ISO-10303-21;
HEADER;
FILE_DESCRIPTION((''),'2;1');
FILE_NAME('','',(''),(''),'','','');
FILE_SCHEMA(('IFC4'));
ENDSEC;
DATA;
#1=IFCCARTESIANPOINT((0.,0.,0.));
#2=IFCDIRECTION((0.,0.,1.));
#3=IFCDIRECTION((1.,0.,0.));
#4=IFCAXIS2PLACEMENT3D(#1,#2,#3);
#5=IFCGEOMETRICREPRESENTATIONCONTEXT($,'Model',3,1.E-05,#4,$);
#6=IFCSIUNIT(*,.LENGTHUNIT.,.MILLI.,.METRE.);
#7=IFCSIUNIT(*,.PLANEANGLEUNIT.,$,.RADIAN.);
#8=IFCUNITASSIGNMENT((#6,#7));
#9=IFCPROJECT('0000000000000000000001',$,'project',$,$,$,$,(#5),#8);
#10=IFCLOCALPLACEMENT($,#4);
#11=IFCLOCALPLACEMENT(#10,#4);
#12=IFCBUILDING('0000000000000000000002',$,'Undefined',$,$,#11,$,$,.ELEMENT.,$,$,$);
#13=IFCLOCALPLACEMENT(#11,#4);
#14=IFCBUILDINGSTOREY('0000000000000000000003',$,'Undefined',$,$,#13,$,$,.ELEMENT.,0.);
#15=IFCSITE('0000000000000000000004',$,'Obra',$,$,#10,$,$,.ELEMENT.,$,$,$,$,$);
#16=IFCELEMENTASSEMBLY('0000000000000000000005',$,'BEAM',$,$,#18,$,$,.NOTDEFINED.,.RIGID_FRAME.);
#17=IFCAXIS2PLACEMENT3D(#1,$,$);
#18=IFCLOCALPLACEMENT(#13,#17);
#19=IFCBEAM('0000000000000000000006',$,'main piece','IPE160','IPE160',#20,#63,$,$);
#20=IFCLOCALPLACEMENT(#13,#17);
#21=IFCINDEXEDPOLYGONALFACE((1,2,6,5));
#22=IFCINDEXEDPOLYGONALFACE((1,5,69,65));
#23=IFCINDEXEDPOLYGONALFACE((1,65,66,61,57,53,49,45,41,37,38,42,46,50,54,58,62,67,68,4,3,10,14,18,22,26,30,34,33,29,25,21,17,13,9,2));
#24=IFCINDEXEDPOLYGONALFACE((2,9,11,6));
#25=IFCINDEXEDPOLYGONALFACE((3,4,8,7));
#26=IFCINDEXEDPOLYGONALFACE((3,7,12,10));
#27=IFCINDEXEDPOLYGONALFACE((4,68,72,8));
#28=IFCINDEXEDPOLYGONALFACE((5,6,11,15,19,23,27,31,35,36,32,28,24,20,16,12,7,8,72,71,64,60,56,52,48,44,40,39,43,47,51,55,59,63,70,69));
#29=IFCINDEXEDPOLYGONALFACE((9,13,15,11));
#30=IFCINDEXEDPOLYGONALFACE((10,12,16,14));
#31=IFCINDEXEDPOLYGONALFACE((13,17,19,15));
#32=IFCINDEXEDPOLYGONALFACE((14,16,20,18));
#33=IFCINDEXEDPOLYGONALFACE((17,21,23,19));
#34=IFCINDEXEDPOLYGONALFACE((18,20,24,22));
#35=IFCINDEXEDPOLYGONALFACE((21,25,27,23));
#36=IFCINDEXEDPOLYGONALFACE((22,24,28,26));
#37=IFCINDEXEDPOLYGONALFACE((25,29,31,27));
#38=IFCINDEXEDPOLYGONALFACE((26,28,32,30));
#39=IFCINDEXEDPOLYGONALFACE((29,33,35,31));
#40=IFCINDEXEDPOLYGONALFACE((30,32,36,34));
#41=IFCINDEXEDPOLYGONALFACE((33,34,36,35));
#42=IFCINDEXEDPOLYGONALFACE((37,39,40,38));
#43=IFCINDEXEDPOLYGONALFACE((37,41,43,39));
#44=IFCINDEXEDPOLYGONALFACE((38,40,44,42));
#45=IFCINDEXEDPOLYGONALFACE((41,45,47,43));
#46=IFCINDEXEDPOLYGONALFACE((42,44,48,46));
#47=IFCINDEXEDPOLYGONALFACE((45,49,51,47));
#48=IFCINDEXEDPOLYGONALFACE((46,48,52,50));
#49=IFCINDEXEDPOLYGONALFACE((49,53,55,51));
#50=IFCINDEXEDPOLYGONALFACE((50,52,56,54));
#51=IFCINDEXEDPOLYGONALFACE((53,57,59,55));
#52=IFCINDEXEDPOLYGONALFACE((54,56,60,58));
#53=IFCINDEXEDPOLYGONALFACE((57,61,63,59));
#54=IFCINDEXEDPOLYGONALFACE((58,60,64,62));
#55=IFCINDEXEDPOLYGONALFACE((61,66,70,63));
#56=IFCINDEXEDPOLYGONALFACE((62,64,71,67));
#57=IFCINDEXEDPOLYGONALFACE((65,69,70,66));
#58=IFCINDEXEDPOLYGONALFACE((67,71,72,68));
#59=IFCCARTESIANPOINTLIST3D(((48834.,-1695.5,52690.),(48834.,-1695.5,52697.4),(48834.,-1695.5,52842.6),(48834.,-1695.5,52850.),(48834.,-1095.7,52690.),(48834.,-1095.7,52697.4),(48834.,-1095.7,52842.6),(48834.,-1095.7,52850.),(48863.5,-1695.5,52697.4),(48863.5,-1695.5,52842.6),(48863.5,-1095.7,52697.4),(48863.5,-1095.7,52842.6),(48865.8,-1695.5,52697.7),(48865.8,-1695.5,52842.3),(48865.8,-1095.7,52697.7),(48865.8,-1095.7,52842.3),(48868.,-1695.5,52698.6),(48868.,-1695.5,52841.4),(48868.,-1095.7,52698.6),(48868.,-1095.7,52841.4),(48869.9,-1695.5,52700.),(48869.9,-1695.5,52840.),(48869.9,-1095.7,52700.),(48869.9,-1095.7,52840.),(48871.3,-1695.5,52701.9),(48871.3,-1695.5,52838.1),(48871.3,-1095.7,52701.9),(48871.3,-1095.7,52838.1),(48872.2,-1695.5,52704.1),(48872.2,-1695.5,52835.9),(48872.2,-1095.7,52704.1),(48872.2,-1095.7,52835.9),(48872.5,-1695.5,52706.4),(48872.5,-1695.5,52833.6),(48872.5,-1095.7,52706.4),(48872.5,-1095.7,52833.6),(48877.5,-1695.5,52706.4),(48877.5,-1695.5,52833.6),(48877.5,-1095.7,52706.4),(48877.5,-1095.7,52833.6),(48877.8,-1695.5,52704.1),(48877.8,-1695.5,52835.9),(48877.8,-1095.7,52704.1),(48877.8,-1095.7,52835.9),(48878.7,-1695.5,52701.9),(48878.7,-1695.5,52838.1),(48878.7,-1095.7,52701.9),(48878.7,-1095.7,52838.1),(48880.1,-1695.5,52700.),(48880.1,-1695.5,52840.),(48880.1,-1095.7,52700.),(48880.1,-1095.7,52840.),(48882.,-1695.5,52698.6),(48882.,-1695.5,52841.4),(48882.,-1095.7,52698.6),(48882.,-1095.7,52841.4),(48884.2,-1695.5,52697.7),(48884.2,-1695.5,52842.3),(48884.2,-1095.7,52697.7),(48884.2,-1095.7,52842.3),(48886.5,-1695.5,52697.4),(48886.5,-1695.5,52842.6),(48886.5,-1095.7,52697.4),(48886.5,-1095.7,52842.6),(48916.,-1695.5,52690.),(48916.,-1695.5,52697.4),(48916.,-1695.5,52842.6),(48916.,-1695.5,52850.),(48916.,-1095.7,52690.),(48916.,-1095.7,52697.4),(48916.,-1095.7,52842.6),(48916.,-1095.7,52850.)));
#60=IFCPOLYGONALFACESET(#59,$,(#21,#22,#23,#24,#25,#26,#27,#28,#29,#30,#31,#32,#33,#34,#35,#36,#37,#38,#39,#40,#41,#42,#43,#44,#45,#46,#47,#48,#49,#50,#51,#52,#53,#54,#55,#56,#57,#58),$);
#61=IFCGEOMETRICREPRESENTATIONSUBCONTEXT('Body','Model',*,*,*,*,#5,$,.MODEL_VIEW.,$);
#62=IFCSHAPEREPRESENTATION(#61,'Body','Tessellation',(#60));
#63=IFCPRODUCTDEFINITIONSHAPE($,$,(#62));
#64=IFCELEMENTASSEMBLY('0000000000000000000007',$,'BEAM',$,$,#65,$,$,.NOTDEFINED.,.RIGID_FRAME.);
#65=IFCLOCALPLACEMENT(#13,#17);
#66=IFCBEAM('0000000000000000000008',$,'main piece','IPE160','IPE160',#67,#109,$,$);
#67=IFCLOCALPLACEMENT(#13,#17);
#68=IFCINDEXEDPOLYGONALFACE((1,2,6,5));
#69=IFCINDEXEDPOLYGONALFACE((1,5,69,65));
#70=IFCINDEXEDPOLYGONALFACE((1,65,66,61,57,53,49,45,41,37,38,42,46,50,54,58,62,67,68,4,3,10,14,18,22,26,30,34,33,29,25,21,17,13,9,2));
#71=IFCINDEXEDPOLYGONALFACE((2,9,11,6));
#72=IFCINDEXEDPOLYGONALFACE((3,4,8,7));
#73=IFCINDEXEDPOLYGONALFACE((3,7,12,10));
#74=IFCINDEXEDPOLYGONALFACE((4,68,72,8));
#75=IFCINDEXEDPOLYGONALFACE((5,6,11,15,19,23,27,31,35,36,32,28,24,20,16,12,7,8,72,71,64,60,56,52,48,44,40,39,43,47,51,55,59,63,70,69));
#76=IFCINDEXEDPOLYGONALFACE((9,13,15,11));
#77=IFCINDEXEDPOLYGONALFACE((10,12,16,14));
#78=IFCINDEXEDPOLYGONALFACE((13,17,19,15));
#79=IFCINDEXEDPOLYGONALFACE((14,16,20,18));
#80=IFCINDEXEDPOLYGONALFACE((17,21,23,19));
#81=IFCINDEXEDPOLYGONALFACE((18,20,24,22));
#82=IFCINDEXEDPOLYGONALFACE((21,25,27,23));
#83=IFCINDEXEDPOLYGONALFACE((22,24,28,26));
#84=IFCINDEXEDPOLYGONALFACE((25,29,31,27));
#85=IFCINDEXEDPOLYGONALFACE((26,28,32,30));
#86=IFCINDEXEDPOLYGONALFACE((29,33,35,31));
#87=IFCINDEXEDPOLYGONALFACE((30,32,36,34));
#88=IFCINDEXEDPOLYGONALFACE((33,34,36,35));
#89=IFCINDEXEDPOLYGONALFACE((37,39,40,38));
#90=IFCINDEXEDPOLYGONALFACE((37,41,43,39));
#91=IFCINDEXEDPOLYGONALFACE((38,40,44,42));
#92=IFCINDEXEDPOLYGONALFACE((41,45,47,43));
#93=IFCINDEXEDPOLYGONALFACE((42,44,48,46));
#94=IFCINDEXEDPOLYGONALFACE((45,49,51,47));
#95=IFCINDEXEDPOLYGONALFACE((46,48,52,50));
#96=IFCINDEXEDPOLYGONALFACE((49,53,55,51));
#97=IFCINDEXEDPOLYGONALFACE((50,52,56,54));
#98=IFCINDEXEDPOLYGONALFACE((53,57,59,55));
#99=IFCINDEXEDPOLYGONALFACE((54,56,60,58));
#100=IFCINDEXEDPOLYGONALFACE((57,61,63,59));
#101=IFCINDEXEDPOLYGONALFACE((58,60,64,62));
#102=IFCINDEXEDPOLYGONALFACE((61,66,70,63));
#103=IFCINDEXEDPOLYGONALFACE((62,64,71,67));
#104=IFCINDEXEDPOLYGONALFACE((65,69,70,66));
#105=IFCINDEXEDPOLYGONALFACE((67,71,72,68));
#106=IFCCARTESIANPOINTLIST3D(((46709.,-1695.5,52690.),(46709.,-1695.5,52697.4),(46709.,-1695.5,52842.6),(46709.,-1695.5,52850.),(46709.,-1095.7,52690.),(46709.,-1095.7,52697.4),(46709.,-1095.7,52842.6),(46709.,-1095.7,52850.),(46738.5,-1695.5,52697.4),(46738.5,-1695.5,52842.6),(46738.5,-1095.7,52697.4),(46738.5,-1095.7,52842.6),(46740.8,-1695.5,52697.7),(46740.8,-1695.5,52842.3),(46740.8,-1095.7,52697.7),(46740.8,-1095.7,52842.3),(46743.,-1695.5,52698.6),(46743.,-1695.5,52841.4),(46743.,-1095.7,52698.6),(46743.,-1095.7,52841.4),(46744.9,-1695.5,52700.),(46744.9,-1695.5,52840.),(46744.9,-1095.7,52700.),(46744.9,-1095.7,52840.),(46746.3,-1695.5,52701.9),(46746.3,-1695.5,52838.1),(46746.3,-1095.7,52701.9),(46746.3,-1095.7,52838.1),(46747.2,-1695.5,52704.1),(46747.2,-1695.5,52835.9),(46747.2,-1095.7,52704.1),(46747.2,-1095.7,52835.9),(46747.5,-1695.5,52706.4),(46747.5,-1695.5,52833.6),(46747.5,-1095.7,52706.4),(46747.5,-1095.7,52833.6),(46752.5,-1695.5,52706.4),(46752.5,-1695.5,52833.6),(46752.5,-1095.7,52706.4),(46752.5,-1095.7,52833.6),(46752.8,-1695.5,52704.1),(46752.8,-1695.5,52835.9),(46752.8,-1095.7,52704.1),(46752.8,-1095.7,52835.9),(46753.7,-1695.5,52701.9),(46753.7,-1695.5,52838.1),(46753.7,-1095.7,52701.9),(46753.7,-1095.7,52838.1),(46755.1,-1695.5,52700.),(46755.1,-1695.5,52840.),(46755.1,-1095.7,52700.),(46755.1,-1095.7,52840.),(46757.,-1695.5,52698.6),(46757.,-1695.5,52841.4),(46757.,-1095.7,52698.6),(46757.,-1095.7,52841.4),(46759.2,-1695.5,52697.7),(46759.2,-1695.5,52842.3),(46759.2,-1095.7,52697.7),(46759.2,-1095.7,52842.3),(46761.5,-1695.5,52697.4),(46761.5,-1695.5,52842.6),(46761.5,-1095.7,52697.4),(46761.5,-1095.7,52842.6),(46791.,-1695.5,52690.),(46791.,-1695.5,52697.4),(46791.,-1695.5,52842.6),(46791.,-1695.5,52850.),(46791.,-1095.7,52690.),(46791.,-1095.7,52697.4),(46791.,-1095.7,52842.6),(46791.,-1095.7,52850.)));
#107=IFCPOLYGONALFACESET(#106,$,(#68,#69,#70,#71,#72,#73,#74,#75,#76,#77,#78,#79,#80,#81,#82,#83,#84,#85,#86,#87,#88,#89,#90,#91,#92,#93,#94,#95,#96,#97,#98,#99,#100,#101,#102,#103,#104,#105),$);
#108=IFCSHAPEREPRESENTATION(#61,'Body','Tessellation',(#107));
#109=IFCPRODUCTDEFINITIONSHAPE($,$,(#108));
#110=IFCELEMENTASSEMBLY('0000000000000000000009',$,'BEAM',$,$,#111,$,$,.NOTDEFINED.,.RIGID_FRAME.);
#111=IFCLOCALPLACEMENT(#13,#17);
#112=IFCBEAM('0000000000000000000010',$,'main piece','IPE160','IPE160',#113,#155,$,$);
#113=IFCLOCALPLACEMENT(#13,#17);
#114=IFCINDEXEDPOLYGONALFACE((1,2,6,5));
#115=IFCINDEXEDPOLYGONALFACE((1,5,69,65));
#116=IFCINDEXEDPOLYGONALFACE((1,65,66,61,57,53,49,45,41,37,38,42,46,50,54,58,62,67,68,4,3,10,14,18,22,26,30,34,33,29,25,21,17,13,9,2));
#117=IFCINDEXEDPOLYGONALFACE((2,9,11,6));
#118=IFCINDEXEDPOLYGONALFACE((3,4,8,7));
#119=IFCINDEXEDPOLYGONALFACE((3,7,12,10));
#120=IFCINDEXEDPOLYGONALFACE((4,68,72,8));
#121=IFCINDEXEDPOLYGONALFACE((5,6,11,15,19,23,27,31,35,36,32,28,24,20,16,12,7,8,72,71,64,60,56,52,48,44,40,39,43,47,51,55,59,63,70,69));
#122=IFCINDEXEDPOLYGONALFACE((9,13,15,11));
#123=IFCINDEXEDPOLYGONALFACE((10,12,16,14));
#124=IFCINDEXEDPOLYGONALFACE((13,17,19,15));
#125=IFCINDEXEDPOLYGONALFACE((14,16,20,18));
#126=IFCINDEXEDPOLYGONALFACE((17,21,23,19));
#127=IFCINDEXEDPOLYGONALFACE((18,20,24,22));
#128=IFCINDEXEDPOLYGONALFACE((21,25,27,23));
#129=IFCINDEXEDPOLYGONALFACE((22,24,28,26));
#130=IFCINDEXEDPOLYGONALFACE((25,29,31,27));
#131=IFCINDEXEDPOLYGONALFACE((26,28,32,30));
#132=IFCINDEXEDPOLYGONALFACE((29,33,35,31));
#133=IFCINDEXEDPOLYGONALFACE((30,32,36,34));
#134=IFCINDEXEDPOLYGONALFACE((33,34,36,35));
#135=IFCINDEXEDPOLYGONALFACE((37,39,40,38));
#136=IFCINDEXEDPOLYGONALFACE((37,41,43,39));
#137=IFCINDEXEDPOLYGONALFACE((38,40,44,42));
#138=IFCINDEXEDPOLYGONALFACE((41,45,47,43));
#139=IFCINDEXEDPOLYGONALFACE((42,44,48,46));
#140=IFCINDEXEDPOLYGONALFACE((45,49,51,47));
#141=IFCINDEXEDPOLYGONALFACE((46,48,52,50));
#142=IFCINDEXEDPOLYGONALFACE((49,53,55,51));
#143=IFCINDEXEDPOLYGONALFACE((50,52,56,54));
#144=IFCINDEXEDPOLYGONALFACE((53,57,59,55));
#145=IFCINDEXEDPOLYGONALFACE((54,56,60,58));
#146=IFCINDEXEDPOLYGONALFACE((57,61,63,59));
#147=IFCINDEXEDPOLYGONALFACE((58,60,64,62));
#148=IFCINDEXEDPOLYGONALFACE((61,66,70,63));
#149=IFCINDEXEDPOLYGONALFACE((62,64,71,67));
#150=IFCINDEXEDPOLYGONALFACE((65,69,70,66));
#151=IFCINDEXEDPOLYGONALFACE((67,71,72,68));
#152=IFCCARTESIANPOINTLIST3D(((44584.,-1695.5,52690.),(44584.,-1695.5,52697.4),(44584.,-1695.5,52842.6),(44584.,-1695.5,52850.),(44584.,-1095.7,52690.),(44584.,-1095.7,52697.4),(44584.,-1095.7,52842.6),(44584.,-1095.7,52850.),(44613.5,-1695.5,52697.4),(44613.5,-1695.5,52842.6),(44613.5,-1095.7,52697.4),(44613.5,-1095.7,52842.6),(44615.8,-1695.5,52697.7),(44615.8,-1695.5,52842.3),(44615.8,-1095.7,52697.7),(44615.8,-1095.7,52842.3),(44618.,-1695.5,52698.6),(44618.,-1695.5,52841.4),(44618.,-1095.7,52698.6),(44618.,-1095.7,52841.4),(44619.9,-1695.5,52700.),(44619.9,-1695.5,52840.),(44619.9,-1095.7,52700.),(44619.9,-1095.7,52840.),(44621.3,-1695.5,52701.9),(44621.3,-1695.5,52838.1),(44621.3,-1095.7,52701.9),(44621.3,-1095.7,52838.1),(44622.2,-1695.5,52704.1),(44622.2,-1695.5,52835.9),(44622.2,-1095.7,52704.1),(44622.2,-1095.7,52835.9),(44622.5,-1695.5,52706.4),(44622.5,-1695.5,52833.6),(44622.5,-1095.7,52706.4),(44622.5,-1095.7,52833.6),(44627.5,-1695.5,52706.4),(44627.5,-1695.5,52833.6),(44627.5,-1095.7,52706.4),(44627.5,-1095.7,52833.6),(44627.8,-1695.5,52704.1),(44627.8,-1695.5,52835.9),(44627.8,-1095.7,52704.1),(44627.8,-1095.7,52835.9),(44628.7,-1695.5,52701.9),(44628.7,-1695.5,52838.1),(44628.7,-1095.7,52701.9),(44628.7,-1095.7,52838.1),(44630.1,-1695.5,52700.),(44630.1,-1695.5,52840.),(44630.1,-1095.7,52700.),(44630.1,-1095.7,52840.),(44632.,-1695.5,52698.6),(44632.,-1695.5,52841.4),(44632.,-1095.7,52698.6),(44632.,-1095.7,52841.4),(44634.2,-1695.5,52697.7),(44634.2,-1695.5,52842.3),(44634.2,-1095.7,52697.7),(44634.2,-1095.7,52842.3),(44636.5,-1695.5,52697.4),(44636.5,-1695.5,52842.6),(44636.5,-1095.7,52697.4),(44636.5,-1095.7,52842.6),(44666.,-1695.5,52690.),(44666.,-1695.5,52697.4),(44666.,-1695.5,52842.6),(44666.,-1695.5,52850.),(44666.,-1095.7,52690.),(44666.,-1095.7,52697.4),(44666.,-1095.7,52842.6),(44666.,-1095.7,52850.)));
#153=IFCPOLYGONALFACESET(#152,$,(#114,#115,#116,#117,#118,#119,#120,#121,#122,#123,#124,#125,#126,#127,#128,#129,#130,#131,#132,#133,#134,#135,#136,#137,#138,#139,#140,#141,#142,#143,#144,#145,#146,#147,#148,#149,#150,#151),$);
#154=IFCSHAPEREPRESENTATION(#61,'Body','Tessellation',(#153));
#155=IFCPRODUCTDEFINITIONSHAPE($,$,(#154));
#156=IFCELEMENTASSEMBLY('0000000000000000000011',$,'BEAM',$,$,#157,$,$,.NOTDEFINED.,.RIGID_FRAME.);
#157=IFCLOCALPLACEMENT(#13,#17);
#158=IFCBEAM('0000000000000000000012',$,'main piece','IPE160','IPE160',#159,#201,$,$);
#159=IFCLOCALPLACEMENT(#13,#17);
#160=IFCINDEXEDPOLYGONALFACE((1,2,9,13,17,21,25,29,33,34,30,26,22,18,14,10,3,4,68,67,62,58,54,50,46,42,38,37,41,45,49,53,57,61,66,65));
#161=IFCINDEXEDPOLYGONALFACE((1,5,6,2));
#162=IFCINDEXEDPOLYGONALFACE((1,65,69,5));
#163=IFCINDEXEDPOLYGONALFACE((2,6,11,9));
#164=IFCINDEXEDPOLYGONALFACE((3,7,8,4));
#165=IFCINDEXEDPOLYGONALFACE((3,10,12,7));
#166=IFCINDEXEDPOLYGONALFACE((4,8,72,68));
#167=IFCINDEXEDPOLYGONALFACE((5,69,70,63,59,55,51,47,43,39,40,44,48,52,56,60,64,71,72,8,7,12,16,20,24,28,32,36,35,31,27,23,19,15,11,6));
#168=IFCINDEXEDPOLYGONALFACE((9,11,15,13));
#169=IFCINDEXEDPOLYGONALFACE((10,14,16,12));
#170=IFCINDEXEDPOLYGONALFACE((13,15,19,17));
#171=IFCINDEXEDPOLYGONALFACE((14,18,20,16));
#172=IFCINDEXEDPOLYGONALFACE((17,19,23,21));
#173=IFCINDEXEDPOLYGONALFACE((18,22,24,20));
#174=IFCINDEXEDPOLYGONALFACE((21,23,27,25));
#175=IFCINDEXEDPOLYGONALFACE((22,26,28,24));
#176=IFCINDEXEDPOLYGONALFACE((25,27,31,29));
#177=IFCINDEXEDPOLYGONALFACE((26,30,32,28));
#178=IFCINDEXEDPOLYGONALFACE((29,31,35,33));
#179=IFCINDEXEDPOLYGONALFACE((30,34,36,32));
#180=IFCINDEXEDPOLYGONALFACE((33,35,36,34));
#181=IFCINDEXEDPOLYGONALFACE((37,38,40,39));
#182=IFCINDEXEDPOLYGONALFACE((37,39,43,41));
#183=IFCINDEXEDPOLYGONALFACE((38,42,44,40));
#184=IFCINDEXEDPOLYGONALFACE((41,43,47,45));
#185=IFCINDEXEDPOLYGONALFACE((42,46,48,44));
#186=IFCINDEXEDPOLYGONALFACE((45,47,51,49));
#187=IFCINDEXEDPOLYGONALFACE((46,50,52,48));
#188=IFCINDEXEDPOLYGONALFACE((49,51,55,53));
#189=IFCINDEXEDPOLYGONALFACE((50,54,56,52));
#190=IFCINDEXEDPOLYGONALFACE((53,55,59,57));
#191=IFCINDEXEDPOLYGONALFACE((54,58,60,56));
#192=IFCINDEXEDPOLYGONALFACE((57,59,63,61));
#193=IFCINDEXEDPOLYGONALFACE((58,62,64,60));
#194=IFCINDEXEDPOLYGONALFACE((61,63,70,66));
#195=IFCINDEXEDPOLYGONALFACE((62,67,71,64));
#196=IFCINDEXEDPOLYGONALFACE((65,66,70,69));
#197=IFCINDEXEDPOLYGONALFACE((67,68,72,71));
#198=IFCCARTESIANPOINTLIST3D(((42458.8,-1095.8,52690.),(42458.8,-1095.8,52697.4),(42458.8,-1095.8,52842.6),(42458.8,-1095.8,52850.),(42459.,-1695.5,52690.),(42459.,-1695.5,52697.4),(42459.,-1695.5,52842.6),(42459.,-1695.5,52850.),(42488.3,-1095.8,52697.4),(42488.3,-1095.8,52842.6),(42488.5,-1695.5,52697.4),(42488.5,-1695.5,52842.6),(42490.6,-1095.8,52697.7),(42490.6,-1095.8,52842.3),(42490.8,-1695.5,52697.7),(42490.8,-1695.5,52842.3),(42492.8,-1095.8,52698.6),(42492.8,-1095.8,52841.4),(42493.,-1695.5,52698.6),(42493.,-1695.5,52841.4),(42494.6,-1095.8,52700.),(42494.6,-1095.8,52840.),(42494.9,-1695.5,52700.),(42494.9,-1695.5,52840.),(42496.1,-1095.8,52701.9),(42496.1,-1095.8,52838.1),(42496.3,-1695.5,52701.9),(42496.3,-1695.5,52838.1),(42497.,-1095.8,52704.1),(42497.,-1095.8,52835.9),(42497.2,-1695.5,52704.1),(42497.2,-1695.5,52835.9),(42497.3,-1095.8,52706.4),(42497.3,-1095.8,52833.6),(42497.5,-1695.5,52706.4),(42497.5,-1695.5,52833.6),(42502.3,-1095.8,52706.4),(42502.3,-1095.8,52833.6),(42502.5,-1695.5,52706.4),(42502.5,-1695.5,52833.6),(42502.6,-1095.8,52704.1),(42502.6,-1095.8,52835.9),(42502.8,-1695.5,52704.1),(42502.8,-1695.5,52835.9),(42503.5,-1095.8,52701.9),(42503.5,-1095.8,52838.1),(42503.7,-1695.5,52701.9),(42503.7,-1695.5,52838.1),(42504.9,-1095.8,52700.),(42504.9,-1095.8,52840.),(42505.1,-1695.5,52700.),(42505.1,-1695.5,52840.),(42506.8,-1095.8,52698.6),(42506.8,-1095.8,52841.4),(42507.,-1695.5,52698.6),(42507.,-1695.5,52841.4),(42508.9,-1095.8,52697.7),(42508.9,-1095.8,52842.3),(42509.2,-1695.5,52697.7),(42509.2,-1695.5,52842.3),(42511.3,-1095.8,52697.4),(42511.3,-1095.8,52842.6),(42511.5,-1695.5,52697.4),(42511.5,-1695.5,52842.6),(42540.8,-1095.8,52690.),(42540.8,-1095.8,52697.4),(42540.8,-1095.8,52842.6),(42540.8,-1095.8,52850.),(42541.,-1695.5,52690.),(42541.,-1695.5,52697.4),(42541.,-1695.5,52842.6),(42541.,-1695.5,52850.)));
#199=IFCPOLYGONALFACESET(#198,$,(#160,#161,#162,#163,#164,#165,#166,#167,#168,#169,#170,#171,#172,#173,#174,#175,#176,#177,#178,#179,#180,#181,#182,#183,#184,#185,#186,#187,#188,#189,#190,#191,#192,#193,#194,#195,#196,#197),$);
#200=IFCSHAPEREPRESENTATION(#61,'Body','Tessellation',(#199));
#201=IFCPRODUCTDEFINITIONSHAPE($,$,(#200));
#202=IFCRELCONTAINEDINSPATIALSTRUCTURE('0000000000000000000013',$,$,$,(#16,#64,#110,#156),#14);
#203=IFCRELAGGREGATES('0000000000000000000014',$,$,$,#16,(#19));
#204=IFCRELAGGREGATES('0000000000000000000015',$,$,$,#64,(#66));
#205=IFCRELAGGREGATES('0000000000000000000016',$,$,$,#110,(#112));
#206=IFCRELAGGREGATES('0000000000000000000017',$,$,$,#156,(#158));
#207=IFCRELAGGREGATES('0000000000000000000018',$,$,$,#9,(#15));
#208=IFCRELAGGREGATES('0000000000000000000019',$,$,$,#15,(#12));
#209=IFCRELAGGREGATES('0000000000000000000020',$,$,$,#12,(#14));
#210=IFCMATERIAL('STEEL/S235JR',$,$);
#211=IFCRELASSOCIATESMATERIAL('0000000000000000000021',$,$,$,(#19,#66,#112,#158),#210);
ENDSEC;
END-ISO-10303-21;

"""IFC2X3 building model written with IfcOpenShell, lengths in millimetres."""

from ifc_helpers import new_model, si_unit, frame, origin_with_axes, origin_2d_with_axis, place, context, subcontext, project, spatial, i_section, extrude, material, element, aggregate, save


model = new_model("IFC2X3")

# Units and contexts
model_context = context("Model", 3, precision=1e-05, world=origin_with_axes())
body_context = subcontext(model_context, "Body", "Model", "MODEL_VIEW")
ifc_project = project(units=[si_unit("LENGTHUNIT", "METRE", prefix="MILLI"), si_unit("PLANEANGLEUNIT", "RADIAN")], contexts=[model_context])

# Site, building, storey
site_placement = place(None, origin_with_axes())
site = spatial("IfcSite", under=ifc_project, at=site_placement, Name="Obra", CompositionType="ELEMENT")
building_placement = place(site_placement, origin_with_axes())
building = spatial("IfcBuilding", under=site, at=building_placement, Name="Undefined", CompositionType="ELEMENT")
storey_placement = place(building_placement, origin_with_axes())
storey = spatial("IfcBuildingStorey", under=building, at=storey_placement, Name="Undefined", CompositionType="ELEMENT", Elevation=0.0)

# Shared definitions
ifc_material_1 = material(Name="STEEL/S235JR")

# Element assemblies, beams
assembly_1_placement = place(storey_placement, origin_with_axes())
assembly_1 = element("IfcElementAssembly", 1, at=assembly_1_placement, inside=storey, Name="BEAM", AssemblyPlace="NOTDEFINED", PredefinedType="RIGID_FRAME")
beam_1_placement = place(assembly_1_placement, frame((48875.0, -1695.5, 52770.0), z_axis=(0.0, 0.0, 1.0), x_axis=(0.0, 1.0, 0.0)))
beam_1 = element("IfcBeam", 2, at=beam_1_placement, material=ifc_material_1, Name="main piece", Description="IPE160", ObjectType="IPE160", context=body_context, shape_type="SweptSolid", body=[
    extrude(i_section(OverallWidth=82.0, OverallDepth=160.0, WebThickness=5.0, FlangeThickness=7.4, FilletRadius=9.0, at=origin_2d_with_axis()), frame((599.8, 0.0, 0.0), z_axis=(-1.0, 0.0, 0.0), x_axis=(0.0, -1.0, 0.0)), (0.0, 0.0, 1.0), 599.8),
])
aggregate(assembly_1, [beam_1])
assembly_2_placement = place(storey_placement, origin_with_axes())
assembly_2 = element("IfcElementAssembly", 3, at=assembly_2_placement, inside=storey, Name="BEAM", AssemblyPlace="NOTDEFINED", PredefinedType="RIGID_FRAME")
beam_2_placement = place(assembly_2_placement, frame((46750.0, -1095.7, 52770.0), z_axis=(0.0, 0.0, 1.0), x_axis=(0.0, -1.0, 0.0)))
beam_2 = element("IfcBeam", 4, at=beam_2_placement, material=ifc_material_1, Name="main piece", Description="IPE160", ObjectType="IPE160", context=body_context, shape_type="SweptSolid", body=[
    extrude(i_section(OverallWidth=82.0, OverallDepth=160.0, WebThickness=5.0, FlangeThickness=7.4, FilletRadius=9.0, at=origin_2d_with_axis()), frame((599.8, 0.0, 0.0), z_axis=(-1.0, 0.0, 0.0), x_axis=(0.0, -1.0, 0.0)), (0.0, 0.0, 1.0), 599.8),
])
aggregate(assembly_2, [beam_2])
assembly_3_placement = place(storey_placement, origin_with_axes())
assembly_3 = element("IfcElementAssembly", 5, at=assembly_3_placement, inside=storey, Name="BEAM", AssemblyPlace="NOTDEFINED", PredefinedType="RIGID_FRAME")
beam_3_placement = place(assembly_3_placement, frame((44625.0, -1695.5, 52770.0), z_axis=(0.0, 0.0, 1.0), x_axis=(0.0, 1.0, 0.0)))
beam_3 = element("IfcBeam", 6, at=beam_3_placement, material=ifc_material_1, Name="main piece", Description="IPE160", ObjectType="IPE160", context=body_context, shape_type="SweptSolid", body=[
    extrude(i_section(OverallWidth=82.0, OverallDepth=160.0, WebThickness=5.0, FlangeThickness=7.4, FilletRadius=9.0, at=origin_2d_with_axis()), frame((599.8, 0.0, 0.0), z_axis=(-1.0, 0.0, 0.0), x_axis=(0.0, -1.0, 0.0)), (0.0, 0.0, 1.0), 599.8),
])
aggregate(assembly_3, [beam_3])
assembly_4_placement = place(storey_placement, origin_with_axes())
assembly_4 = element("IfcElementAssembly", 7, at=assembly_4_placement, inside=storey, Name="BEAM", AssemblyPlace="NOTDEFINED", PredefinedType="RIGID_FRAME")
beam_4_placement = place(assembly_4_placement, frame((42499.8, -1095.8, 52770.0), z_axis=(0.0, 0.0, 1.0), x_axis=(0.000388, -1.0, 0.0)))
beam_4 = element("IfcBeam", 8, at=beam_4_placement, material=ifc_material_1, Name="main piece", Description="IPE160", ObjectType="IPE160", context=body_context, shape_type="SweptSolid", body=[
    extrude(i_section(OverallWidth=82.0, OverallDepth=160.0, WebThickness=5.0, FlangeThickness=7.4, FilletRadius=9.0, at=origin_2d_with_axis()), frame((599.7, 0.0, 0.0), z_axis=(-1.0, 0.0, 0.0), x_axis=(0.0, -1.0, 0.0)), (0.0, 0.0, 1.0), 599.7),
])
aggregate(assembly_4, [beam_4])

save(model, "model.ifc")
